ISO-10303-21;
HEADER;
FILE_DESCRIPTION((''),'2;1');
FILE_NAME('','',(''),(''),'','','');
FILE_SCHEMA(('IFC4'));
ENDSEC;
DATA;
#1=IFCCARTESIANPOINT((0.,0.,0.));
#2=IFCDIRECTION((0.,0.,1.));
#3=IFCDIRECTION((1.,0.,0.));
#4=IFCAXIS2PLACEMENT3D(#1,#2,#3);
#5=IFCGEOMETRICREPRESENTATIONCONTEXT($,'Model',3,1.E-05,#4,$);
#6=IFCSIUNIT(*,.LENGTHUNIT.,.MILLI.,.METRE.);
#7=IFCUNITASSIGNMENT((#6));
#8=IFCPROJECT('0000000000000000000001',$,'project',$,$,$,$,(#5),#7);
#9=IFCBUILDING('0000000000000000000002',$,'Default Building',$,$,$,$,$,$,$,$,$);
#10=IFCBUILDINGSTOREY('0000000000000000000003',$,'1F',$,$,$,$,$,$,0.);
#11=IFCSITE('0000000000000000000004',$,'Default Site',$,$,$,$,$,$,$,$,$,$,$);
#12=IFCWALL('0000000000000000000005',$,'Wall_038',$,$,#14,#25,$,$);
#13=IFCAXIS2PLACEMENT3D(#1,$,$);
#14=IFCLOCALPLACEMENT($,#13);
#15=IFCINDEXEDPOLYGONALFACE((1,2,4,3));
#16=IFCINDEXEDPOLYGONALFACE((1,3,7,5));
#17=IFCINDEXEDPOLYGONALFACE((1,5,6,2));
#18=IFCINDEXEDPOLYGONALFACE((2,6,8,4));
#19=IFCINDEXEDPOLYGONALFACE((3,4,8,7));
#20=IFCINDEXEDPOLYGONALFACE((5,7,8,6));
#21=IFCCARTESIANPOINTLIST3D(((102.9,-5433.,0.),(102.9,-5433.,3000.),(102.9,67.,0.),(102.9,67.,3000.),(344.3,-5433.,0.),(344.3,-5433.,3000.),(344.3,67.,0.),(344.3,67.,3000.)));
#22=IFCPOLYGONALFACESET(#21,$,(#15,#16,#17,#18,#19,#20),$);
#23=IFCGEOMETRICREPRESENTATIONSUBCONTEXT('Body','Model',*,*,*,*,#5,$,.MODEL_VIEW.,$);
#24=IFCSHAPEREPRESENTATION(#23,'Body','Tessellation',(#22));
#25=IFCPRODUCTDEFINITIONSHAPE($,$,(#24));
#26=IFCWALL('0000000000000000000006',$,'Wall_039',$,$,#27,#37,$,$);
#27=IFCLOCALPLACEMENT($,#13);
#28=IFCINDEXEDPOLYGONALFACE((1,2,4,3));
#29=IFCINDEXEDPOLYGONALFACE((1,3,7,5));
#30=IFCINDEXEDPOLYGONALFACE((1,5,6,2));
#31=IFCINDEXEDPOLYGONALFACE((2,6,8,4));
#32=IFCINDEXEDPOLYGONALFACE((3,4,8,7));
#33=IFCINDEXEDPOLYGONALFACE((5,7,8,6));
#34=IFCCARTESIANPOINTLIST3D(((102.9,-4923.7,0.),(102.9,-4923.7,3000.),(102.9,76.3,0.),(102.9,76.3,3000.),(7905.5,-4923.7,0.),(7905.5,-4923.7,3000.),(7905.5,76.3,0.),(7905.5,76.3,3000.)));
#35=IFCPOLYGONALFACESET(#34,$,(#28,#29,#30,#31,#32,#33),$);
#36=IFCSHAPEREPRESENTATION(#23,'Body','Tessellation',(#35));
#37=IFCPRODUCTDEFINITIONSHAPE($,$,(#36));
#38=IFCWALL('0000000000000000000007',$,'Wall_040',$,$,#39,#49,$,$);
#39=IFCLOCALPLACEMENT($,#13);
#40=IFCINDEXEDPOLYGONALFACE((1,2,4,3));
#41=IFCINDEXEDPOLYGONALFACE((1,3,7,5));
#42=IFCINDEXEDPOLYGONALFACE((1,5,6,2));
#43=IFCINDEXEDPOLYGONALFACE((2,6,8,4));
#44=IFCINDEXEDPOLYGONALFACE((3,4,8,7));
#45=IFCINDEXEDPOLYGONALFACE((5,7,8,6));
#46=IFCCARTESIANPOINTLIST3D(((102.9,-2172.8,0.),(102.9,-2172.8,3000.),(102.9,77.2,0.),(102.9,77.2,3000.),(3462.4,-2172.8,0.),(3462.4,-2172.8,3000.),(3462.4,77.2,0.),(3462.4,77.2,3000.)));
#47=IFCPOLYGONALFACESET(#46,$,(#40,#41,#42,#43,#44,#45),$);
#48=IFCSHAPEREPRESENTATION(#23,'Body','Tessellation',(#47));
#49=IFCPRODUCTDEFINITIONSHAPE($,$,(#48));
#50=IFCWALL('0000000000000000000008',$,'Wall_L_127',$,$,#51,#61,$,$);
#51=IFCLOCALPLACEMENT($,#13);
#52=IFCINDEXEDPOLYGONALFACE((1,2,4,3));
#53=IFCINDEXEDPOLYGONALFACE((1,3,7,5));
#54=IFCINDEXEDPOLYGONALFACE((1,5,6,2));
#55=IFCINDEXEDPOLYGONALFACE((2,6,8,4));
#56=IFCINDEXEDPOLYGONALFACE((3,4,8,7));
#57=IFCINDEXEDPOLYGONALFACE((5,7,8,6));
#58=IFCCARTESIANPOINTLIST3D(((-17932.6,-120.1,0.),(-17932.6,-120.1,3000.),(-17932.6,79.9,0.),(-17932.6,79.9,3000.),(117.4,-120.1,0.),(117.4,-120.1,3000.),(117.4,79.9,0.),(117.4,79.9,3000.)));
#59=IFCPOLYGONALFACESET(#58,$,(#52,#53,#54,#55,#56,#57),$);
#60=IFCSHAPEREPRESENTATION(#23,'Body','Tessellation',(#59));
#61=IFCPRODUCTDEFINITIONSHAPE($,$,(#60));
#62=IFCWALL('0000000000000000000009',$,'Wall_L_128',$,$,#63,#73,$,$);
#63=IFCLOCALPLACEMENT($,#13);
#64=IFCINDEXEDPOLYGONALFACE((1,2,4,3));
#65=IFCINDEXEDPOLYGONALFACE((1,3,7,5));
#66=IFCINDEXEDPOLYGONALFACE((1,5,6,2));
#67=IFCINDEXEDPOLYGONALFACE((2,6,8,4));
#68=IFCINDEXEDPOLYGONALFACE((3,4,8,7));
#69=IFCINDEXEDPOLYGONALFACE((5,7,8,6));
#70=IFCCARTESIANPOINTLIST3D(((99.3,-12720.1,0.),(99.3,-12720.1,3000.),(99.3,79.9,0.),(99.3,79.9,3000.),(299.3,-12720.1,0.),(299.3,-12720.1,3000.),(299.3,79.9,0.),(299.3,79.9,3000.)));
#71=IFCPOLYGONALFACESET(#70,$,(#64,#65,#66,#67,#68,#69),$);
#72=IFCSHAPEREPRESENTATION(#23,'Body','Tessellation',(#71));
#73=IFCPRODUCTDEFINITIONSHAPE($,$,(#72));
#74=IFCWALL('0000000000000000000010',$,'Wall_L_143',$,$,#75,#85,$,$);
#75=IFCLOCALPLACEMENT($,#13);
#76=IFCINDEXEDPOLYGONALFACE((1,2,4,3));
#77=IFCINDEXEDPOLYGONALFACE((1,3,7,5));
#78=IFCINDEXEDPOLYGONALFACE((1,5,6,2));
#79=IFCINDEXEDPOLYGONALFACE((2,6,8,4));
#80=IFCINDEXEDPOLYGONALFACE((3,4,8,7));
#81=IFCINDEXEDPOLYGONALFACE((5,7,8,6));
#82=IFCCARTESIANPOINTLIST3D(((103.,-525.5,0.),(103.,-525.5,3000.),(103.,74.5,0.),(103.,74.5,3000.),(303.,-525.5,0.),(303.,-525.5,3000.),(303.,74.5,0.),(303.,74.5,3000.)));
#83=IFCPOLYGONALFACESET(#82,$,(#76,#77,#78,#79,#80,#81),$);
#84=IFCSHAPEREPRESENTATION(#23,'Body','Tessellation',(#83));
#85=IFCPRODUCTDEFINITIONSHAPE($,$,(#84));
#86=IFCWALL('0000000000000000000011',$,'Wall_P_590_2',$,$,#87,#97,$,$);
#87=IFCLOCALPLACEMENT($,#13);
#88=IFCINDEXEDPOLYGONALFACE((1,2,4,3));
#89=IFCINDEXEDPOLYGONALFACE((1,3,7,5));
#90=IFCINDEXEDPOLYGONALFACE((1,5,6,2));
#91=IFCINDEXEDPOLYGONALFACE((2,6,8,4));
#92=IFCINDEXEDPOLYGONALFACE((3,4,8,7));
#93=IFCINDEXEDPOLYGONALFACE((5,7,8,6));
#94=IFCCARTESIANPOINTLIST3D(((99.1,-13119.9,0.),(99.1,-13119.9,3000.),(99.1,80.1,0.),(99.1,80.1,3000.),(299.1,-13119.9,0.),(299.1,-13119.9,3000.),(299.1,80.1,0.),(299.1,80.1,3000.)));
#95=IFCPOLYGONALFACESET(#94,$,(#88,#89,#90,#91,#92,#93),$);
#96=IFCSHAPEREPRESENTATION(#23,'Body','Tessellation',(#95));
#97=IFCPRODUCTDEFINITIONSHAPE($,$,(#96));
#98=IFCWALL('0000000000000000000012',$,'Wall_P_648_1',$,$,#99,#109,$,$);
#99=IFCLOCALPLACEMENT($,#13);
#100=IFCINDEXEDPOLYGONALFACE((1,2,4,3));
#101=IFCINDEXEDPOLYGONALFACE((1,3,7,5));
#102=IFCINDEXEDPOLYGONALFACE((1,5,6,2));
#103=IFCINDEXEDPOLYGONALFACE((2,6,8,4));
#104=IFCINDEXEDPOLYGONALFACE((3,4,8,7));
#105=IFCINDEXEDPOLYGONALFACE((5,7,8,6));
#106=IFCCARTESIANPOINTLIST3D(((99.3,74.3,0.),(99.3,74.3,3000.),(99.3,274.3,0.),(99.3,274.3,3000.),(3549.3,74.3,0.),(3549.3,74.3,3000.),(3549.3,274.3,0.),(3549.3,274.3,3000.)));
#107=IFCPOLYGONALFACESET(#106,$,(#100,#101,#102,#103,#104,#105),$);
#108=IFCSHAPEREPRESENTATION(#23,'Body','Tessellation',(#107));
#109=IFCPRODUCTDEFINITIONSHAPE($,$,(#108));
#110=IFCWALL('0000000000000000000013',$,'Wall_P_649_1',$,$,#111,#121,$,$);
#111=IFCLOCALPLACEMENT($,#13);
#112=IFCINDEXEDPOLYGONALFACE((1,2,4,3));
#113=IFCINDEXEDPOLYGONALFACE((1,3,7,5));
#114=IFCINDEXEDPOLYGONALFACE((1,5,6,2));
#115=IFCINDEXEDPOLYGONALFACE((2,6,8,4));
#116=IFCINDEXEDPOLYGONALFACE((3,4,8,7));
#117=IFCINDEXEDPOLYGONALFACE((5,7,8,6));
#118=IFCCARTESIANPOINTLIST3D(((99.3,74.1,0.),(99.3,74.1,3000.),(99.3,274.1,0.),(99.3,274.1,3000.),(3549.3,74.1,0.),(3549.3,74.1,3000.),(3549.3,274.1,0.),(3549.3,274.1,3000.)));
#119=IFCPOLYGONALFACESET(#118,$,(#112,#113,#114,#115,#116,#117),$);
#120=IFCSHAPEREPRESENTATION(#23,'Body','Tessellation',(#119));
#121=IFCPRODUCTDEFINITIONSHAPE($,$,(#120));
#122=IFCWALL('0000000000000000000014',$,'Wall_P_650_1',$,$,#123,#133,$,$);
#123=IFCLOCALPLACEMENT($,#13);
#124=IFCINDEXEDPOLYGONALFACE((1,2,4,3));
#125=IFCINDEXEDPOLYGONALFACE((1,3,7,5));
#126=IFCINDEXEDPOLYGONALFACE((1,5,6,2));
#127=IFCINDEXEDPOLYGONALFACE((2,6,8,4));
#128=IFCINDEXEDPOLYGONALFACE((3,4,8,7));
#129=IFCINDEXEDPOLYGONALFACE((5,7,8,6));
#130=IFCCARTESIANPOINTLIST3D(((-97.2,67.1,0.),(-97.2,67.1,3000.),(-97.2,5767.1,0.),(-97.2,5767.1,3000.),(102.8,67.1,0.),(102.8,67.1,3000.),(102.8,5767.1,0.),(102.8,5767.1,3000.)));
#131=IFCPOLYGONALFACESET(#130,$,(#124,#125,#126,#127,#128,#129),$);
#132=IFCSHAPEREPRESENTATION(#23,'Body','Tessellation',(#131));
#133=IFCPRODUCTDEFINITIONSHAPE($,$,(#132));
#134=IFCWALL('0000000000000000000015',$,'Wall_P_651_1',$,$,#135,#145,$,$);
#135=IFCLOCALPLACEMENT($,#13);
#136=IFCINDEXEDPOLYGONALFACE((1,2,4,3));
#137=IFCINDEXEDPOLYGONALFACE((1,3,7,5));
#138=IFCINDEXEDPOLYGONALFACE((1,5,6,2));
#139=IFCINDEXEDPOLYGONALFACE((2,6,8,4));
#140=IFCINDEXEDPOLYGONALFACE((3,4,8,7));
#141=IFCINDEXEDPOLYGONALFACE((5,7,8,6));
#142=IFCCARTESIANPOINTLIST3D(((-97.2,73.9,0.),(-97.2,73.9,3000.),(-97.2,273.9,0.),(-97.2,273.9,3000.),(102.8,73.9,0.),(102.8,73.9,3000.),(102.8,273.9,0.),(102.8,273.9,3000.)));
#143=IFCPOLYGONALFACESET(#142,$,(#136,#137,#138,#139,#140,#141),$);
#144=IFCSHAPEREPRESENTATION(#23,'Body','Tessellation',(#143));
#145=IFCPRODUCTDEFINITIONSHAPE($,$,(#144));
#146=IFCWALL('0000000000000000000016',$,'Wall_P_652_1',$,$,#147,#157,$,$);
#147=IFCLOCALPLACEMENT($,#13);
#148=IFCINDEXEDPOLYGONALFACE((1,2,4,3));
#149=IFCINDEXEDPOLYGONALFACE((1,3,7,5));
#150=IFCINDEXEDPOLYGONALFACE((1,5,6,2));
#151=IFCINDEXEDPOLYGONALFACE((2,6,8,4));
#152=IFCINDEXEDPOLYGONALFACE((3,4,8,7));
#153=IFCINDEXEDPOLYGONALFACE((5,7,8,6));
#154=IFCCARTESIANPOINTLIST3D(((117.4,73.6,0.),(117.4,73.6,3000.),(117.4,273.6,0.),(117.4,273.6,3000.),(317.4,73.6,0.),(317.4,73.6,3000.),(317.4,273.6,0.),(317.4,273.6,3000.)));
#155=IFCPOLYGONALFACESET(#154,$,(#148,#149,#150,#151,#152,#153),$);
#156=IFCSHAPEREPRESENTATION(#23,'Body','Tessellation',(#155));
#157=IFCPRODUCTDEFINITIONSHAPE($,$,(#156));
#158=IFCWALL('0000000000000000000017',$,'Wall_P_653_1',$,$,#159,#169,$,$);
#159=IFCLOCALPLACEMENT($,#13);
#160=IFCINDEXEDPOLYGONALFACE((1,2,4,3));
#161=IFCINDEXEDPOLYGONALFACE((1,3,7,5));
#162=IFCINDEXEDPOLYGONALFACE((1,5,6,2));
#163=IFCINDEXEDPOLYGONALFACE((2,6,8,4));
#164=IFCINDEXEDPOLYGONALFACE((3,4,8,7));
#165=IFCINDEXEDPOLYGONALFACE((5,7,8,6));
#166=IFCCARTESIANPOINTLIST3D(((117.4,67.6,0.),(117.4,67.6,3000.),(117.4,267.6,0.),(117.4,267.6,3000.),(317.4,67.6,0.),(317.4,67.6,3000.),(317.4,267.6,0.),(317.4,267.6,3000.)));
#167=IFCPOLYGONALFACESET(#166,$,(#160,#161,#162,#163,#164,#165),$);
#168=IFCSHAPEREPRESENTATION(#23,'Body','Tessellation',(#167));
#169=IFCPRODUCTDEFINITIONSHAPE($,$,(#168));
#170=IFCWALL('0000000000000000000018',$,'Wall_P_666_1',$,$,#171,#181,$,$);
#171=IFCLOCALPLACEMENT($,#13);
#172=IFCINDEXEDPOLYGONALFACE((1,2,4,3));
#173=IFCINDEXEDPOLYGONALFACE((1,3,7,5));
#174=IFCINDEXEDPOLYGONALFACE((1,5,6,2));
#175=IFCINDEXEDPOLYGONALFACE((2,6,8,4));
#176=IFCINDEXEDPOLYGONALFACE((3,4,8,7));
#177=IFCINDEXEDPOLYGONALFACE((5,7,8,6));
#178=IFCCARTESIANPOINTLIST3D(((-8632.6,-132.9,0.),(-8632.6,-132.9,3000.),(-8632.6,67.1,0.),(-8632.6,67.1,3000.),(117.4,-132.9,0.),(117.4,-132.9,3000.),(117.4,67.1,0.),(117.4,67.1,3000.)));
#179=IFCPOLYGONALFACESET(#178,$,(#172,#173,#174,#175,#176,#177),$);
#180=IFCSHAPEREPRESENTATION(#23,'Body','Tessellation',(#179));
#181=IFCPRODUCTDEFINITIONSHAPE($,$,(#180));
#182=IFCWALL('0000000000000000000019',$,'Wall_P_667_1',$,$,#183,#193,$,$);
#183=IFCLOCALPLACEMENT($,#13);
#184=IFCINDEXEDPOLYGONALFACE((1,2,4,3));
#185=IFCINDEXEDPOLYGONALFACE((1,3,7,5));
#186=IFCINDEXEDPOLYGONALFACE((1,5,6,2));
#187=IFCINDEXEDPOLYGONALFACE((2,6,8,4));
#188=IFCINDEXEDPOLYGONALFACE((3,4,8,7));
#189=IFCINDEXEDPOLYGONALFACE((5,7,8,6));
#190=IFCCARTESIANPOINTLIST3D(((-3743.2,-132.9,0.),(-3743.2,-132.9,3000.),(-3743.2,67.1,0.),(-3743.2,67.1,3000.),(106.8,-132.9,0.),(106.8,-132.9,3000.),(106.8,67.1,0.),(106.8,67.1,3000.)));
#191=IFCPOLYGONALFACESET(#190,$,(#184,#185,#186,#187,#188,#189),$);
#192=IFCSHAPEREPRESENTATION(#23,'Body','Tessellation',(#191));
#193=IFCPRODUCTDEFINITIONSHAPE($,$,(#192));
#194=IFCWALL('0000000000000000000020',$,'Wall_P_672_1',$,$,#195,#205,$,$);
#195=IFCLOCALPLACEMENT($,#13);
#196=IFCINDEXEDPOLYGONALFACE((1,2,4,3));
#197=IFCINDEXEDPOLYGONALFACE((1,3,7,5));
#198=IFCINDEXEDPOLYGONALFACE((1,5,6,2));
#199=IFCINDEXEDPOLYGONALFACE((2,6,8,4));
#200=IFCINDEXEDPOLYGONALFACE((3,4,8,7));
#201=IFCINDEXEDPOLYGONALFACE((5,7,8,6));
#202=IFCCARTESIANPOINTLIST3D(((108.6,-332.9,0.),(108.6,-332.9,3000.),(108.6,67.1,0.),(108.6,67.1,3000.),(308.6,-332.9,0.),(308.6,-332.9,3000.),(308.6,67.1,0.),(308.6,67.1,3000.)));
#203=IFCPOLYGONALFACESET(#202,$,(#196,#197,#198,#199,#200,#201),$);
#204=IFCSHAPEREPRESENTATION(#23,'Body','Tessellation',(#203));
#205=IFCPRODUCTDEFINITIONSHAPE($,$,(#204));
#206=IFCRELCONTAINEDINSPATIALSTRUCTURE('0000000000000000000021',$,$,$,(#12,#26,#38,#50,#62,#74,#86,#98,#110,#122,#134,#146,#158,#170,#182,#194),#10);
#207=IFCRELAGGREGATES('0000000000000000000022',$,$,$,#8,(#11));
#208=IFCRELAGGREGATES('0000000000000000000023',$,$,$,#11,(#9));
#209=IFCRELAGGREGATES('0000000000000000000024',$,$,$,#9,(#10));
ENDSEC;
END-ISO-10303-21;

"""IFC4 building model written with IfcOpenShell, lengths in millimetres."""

from ifc_helpers import new_model, si_unit, frame, origin_with_axes, place, context, subcontext, project, spatial, indexed_curve, outline, extrude, element, save


model = new_model("IFC4")

# Units and contexts
model_context = context("Model", 3, precision=1e-05, world=origin_with_axes())
body_context = subcontext(model_context, "Body", "Model", "MODEL_VIEW")
ifc_project = project(units=[si_unit("LENGTHUNIT", "METRE", prefix="MILLI")], contexts=[model_context])

# Site, building, storey
site = spatial("IfcSite", under=ifc_project, Name="Default Site")
building = spatial("IfcBuilding", under=site, Name="Default Building")
storey = spatial("IfcBuildingStorey", under=building, Name="1F", Elevation=0.0)

# Walls
wall_1_placement = place(None, frame((102.9, 67.0, 0.0), z_axis=(0.0, 0.0, 1.0), x_axis=(0.0, -1.0, 0.0)))
element("IfcWall", 1, at=wall_1_placement, inside=storey, Name="Wall_038", context=body_context, shape_type="SweptSolid", body=[
    extrude(outline(indexed_curve([(0.0, 0.0), (0.0, 241.4), (5500.0, 241.4), (5500.0, 0.0), (0.0, 0.0)], self_intersect=False)), origin_with_axes(), (0.0, 0.0, 1.0), 3000.0),
])
wall_2_placement = place(None, frame((102.9, 76.3, 0.0), z_axis=(0.0, 0.0, 1.0), x_axis=(0.0, -1.0, 0.0)))
element("IfcWall", 2, at=wall_2_placement, inside=storey, Name="Wall_039", context=body_context, shape_type="SweptSolid", body=[
    extrude(outline(indexed_curve([(0.0, 0.0), (0.0, 7802.6), (5000.0, 7802.6), (5000.0, 0.0), (0.0, 0.0)], self_intersect=False)), origin_with_axes(), (0.0, 0.0, 1.0), 3000.0),
])
wall_3_placement = place(None, frame((102.9, 77.2, 0.0), z_axis=(0.0, 0.0, 1.0), x_axis=(0.0, -1.0, 0.0)))
element("IfcWall", 3, at=wall_3_placement, inside=storey, Name="Wall_040", context=body_context, shape_type="SweptSolid", body=[
    extrude(outline(indexed_curve([(0.0, 0.0), (0.0, 3359.5), (2250.0, 3359.5), (2250.0, 0.0), (0.0, 0.0)], self_intersect=False)), origin_with_axes(), (0.0, 0.0, 1.0), 3000.0),
])
wall_4_placement = place(None, frame((117.4, 79.9, 0.0), z_axis=(0.0, 0.0, 1.0), x_axis=(-1.0, 0.0, 0.0)))
element("IfcWall", 4, at=wall_4_placement, inside=storey, Name="Wall_L_127", context=body_context, shape_type="SweptSolid", body=[
    extrude(outline(indexed_curve([(0.0, 0.0), (0.0, 200.0), (18050.0, 200.0), (18050.0, 0.0), (0.0, 0.0)], self_intersect=False)), origin_with_axes(), (0.0, 0.0, 1.0), 3000.0),
])
wall_5_placement = place(None, frame((99.3, 79.9, 0.0), z_axis=(0.0, 0.0, 1.0), x_axis=(0.0, -1.0, 0.0)))
element("IfcWall", 5, at=wall_5_placement, inside=storey, Name="Wall_L_128", context=body_context, shape_type="SweptSolid", body=[
    extrude(outline(indexed_curve([(0.0, 0.0), (0.0, 200.0), (12800.0, 200.0), (12800.0, 0.0), (0.0, 0.0)], self_intersect=False)), origin_with_axes(), (0.0, 0.0, 1.0), 3000.0),
])
wall_6_placement = place(None, frame((103.0, 74.5, 0.0), z_axis=(0.0, 0.0, 1.0), x_axis=(0.0, -1.0, 0.0)))
element("IfcWall", 6, at=wall_6_placement, inside=storey, Name="Wall_L_143", context=body_context, shape_type="SweptSolid", body=[
    extrude(outline(indexed_curve([(0.0, 0.0), (0.0, 200.0), (600.0, 200.0), (600.0, 0.0), (0.0, 0.0)], self_intersect=False)), origin_with_axes(), (0.0, 0.0, 1.0), 3000.0),
])
wall_7_placement = place(None, frame((99.1, 80.1, 0.0), z_axis=(0.0, 0.0, 1.0), x_axis=(0.0, -1.0, 0.0)))
element("IfcWall", 7, at=wall_7_placement, inside=storey, Name="Wall_P_590_2", context=body_context, shape_type="SweptSolid", body=[
    extrude(outline(indexed_curve([(0.0, 0.0), (0.0, 200.0), (13200.0, 200.0), (13200.0, 0.0), (0.0, 0.0)], self_intersect=False)), origin_with_axes(), (0.0, 0.0, 1.0), 3000.0),
])
for number, where, z_axis, x_axis, name in (
    (8, (99.3, 74.3, 0.0), (0.0, 0.0, 1.0), (1.0, 0.0, 0.0), "Wall_P_648_1"),
    (9, (99.3, 74.1, 0.0), (0.0, 0.0, 1.0), (1.0, 0.0, 0.0), "Wall_P_649_1"),
):
    element("IfcWall", number, at=place(None, frame(where, z_axis=z_axis, x_axis=x_axis)), inside=storey, Name=name, context=body_context, shape_type="SweptSolid", body=[
        extrude(outline(indexed_curve([(0.0, 0.0), (0.0, 200.0), (3450.0, 200.0), (3450.0, 0.0), (0.0, 0.0)], self_intersect=False)), origin_with_axes(), (0.0, 0.0, 1.0), 3000.0),
    ])
wall_8_placement = place(None, frame((102.8, 67.1, 0.0), z_axis=(0.0, 0.0, 1.0), x_axis=(0.0, 1.0, 0.0)))
element("IfcWall", 10, at=wall_8_placement, inside=storey, Name="Wall_P_650_1", context=body_context, shape_type="SweptSolid", body=[
    extrude(outline(indexed_curve([(0.0, 0.0), (0.0, 200.0), (5700.0, 200.0), (5700.0, 0.0), (0.0, 0.0)], self_intersect=False)), origin_with_axes(), (0.0, 0.0, 1.0), 3000.0),
])
wall_9_placement = place(None, frame((102.8, 73.9, 0.0), z_axis=(0.0, 0.0, 1.0), x_axis=(0.0, 1.0, 0.0)))
element("IfcWall", 11, at=wall_9_placement, inside=storey, Name="Wall_P_651_1", context=body_context, shape_type="SweptSolid", body=[
    extrude(outline(indexed_curve([(0.0, 0.0), (0.0, 200.0), (200.0, 200.0), (200.0, 0.0), (0.0, 0.0)], self_intersect=False)), origin_with_axes(), (0.0, 0.0, 1.0), 3000.0),
])
for number, where, z_axis, x_axis, name in (
    (12, (117.4, 73.6, 0.0), (0.0, 0.0, 1.0), (1.0, 0.0, 0.0), "Wall_P_652_1"),
    (13, (117.4, 67.6, 0.0), (0.0, 0.0, 1.0), (1.0, 0.0, 0.0), "Wall_P_653_1"),
):
    element("IfcWall", number, at=place(None, frame(where, z_axis=z_axis, x_axis=x_axis)), inside=storey, Name=name, context=body_context, shape_type="SweptSolid", body=[
        extrude(outline(indexed_curve([(0.0, 0.0), (0.0, 200.0), (200.0, 200.0), (200.0, 0.0), (0.0, 0.0)], self_intersect=False)), origin_with_axes(), (0.0, 0.0, 1.0), 3000.0),
    ])
wall_10_placement = place(None, frame((117.4, 67.1, 0.0), z_axis=(0.0, 0.0, 1.0), x_axis=(-1.0, 0.0, 0.0)))
element("IfcWall", 14, at=wall_10_placement, inside=storey, Name="Wall_P_666_1", context=body_context, shape_type="SweptSolid", body=[
    extrude(outline(indexed_curve([(0.0, 0.0), (0.0, 200.0), (8750.0, 200.0), (8750.0, 0.0), (0.0, 0.0)], self_intersect=False)), origin_with_axes(), (0.0, 0.0, 1.0), 3000.0),
])
wall_11_placement = place(None, frame((106.8, 67.1, 0.0), z_axis=(0.0, 0.0, 1.0), x_axis=(-1.0, 0.0, 0.0)))
element("IfcWall", 15, at=wall_11_placement, inside=storey, Name="Wall_P_667_1", context=body_context, shape_type="SweptSolid", body=[
    extrude(outline(indexed_curve([(0.0, 0.0), (0.0, 200.0), (3850.0, 200.0), (3850.0, 0.0), (0.0, 0.0)], self_intersect=False)), origin_with_axes(), (0.0, 0.0, 1.0), 3000.0),
])
wall_12_placement = place(None, frame((108.6, 67.1, 0.0), z_axis=(0.0, 0.0, 1.0), x_axis=(0.0, -1.0, 0.0)))
element("IfcWall", 16, at=wall_12_placement, inside=storey, Name="Wall_P_672_1", context=body_context, shape_type="SweptSolid", body=[
    extrude(outline(indexed_curve([(0.0, 0.0), (0.0, 200.0), (400.0, 200.0), (400.0, 0.0), (0.0, 0.0)], self_intersect=False)), origin_with_axes(), (0.0, 0.0, 1.0), 3000.0),
])

save(model, "model.ifc")
